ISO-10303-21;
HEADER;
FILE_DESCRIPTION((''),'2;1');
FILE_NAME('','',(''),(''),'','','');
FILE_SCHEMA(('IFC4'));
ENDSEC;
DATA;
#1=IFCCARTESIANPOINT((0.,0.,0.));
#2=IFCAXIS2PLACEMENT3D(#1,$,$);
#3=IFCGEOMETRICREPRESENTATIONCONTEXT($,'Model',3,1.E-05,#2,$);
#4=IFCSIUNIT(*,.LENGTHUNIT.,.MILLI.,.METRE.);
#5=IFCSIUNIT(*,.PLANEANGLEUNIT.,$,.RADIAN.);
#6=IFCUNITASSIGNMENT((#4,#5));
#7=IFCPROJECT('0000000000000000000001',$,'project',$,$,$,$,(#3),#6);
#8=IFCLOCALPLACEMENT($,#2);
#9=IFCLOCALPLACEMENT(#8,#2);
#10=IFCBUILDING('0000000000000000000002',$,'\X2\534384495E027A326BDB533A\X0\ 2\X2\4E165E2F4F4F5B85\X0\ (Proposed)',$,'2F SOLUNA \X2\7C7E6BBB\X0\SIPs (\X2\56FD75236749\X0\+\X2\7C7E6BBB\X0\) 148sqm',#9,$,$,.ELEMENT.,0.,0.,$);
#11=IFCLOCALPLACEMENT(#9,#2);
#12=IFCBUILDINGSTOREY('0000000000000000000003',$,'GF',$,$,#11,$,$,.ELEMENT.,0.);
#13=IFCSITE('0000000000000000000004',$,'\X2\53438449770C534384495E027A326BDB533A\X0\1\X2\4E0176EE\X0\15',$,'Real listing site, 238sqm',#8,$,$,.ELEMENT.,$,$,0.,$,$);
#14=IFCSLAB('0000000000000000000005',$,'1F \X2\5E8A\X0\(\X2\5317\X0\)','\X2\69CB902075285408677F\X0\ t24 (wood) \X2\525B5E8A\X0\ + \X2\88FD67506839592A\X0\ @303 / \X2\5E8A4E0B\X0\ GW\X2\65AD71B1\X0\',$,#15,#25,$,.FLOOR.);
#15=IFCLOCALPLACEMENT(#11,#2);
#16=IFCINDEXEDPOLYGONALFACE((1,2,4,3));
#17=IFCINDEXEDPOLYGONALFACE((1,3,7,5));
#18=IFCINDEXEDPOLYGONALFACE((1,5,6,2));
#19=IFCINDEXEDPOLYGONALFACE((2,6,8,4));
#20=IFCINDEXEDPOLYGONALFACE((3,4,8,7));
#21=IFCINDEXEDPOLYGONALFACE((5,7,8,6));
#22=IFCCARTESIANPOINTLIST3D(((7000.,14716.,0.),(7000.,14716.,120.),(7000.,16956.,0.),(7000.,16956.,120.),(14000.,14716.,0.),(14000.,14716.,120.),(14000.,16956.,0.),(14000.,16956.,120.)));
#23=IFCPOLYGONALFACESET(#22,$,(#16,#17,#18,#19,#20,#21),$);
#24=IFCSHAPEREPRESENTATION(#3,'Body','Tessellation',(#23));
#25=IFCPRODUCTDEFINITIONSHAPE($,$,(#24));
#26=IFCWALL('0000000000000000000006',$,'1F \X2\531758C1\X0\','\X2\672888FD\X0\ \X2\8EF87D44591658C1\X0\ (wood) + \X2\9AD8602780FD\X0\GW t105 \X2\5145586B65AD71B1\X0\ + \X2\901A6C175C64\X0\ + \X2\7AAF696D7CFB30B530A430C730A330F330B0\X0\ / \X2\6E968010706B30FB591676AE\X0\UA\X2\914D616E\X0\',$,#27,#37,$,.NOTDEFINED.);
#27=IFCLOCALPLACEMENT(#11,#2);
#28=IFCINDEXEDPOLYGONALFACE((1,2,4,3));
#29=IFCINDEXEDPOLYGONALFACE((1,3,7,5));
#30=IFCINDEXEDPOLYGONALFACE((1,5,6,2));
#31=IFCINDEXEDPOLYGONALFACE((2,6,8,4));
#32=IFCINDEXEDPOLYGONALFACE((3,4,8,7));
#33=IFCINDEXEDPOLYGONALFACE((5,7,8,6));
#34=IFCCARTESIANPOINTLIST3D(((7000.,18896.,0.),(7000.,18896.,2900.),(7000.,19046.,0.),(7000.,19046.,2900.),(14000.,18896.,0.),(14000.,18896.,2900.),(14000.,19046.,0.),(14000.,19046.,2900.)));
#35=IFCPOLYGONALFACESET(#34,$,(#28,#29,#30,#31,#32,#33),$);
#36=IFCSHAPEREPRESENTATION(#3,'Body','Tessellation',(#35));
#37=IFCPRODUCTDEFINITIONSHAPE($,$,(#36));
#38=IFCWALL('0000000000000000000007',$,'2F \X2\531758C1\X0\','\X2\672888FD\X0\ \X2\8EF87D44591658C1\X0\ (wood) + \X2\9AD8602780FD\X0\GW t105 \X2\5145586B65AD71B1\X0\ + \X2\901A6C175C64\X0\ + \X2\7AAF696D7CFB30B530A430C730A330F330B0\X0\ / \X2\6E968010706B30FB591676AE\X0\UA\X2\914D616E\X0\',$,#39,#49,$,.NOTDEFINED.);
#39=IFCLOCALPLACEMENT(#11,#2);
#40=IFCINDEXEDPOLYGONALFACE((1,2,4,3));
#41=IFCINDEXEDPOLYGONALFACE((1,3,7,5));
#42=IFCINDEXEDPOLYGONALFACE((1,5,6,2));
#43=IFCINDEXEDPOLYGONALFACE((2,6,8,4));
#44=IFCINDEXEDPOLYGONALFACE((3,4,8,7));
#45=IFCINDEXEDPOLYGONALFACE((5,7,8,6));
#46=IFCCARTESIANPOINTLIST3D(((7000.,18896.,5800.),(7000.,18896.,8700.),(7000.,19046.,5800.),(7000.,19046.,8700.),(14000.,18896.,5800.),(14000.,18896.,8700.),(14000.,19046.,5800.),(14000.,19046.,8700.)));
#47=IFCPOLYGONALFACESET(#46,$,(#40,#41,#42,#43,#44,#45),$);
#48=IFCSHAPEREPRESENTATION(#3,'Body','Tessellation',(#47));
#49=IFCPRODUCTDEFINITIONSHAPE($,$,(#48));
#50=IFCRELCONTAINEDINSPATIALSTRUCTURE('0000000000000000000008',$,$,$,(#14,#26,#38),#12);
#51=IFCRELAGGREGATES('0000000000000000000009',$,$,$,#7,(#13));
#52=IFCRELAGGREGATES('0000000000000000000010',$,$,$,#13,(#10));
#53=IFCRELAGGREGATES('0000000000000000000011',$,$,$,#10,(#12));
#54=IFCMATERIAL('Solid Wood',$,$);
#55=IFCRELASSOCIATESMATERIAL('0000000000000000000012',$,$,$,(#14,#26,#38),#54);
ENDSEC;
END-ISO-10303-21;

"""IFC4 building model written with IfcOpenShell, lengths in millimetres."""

from ifc_helpers import new_model, si_unit, frame, frame_2d, origin, place, context, project, spatial, rectangle, extrude, material, element, save


model = new_model("IFC4")

# Units and contexts
model_context = context("Model", 3, precision=1e-05, world=origin())
ifc_project = project(units=[si_unit("LENGTHUNIT", "METRE", prefix="MILLI"), si_unit("PLANEANGLEUNIT", "RADIAN")], contexts=[model_context])

# Site, building, storey
site_placement = place(None, origin())
site = spatial("IfcSite", under=ifc_project, at=site_placement, Name="千葉県千葉市稲毛区1丁目15", ObjectType="Real listing site, 238sqm", CompositionType="ELEMENT", RefElevation=0.0)
building_placement = place(site_placement, origin())
building = spatial("IfcBuilding", under=site, at=building_placement, Name="千葉市稲毛区 2世帯住宅 (Proposed)", ObjectType="2F SOLUNA 籾殻SIPs (国産杉+籾殻) 148sqm", CompositionType="ELEMENT", ElevationOfRefHeight=0.0, ElevationOfTerrain=0.0)
storey_placement = place(building_placement, origin())
storey = spatial("IfcBuildingStorey", under=building, at=storey_placement, Name="GF", CompositionType="ELEMENT", Elevation=0.0)

# Slab
ifc_material_1 = material(Name="Solid Wood")
slab_1_placement = place(storey_placement, frame((3500.0, 7358.0, 0.0)))
element("IfcSlab", 1, at=slab_1_placement, inside=storey, material=ifc_material_1, Name="1F 床(北)", Description="構造用合板 t24 (wood) 剛床 + 製材根太 @303 / 床下 GW断熱", PredefinedType="FLOOR", context=model_context, shape_type="SweptSolid", body=[
    extrude(rectangle(XDim=7000.0, YDim=2240.0, at=frame_2d((3500.0, 1120.0))), frame((3500.0, 7358.0, 0.0)), (0.0, 0.0, 1.0), 120.0),
])

# Wall
wall_1_placement = place(storey_placement, frame((3500.0, 9448.0, 0.0)))
element("IfcWall", 2, at=wall_1_placement, inside=storey, material=ifc_material_1, Name="1F 北壁", Description="木製 軸組外壁 (wood) + 高性能GW t105 充填断熱 + 通気層 + 窯業系サイディング / 準耐火・外皮UA配慮", PredefinedType="NOTDEFINED", context=model_context, shape_type="SweptSolid", body=[
    extrude(rectangle(XDim=7000.0, YDim=150.0, at=frame_2d((3500.0, 75.0))), frame((3500.0, 9448.0, 0.0)), (0.0, 0.0, 1.0), 2900.0),
])

# Wall
wall_2_placement = place(storey_placement, frame((3500.0, 9448.0, 2900.0)))
element("IfcWall", 3, at=wall_2_placement, inside=storey, material=ifc_material_1, Name="2F 北壁", Description="木製 軸組外壁 (wood) + 高性能GW t105 充填断熱 + 通気層 + 窯業系サイディング / 準耐火・外皮UA配慮", PredefinedType="NOTDEFINED", context=model_context, shape_type="SweptSolid", body=[
    extrude(rectangle(XDim=7000.0, YDim=150.0, at=frame_2d((3500.0, 75.0))), frame((3500.0, 9448.0, 2900.0)), (0.0, 0.0, 1.0), 2900.0),
])

save(model, "model.ifc")
